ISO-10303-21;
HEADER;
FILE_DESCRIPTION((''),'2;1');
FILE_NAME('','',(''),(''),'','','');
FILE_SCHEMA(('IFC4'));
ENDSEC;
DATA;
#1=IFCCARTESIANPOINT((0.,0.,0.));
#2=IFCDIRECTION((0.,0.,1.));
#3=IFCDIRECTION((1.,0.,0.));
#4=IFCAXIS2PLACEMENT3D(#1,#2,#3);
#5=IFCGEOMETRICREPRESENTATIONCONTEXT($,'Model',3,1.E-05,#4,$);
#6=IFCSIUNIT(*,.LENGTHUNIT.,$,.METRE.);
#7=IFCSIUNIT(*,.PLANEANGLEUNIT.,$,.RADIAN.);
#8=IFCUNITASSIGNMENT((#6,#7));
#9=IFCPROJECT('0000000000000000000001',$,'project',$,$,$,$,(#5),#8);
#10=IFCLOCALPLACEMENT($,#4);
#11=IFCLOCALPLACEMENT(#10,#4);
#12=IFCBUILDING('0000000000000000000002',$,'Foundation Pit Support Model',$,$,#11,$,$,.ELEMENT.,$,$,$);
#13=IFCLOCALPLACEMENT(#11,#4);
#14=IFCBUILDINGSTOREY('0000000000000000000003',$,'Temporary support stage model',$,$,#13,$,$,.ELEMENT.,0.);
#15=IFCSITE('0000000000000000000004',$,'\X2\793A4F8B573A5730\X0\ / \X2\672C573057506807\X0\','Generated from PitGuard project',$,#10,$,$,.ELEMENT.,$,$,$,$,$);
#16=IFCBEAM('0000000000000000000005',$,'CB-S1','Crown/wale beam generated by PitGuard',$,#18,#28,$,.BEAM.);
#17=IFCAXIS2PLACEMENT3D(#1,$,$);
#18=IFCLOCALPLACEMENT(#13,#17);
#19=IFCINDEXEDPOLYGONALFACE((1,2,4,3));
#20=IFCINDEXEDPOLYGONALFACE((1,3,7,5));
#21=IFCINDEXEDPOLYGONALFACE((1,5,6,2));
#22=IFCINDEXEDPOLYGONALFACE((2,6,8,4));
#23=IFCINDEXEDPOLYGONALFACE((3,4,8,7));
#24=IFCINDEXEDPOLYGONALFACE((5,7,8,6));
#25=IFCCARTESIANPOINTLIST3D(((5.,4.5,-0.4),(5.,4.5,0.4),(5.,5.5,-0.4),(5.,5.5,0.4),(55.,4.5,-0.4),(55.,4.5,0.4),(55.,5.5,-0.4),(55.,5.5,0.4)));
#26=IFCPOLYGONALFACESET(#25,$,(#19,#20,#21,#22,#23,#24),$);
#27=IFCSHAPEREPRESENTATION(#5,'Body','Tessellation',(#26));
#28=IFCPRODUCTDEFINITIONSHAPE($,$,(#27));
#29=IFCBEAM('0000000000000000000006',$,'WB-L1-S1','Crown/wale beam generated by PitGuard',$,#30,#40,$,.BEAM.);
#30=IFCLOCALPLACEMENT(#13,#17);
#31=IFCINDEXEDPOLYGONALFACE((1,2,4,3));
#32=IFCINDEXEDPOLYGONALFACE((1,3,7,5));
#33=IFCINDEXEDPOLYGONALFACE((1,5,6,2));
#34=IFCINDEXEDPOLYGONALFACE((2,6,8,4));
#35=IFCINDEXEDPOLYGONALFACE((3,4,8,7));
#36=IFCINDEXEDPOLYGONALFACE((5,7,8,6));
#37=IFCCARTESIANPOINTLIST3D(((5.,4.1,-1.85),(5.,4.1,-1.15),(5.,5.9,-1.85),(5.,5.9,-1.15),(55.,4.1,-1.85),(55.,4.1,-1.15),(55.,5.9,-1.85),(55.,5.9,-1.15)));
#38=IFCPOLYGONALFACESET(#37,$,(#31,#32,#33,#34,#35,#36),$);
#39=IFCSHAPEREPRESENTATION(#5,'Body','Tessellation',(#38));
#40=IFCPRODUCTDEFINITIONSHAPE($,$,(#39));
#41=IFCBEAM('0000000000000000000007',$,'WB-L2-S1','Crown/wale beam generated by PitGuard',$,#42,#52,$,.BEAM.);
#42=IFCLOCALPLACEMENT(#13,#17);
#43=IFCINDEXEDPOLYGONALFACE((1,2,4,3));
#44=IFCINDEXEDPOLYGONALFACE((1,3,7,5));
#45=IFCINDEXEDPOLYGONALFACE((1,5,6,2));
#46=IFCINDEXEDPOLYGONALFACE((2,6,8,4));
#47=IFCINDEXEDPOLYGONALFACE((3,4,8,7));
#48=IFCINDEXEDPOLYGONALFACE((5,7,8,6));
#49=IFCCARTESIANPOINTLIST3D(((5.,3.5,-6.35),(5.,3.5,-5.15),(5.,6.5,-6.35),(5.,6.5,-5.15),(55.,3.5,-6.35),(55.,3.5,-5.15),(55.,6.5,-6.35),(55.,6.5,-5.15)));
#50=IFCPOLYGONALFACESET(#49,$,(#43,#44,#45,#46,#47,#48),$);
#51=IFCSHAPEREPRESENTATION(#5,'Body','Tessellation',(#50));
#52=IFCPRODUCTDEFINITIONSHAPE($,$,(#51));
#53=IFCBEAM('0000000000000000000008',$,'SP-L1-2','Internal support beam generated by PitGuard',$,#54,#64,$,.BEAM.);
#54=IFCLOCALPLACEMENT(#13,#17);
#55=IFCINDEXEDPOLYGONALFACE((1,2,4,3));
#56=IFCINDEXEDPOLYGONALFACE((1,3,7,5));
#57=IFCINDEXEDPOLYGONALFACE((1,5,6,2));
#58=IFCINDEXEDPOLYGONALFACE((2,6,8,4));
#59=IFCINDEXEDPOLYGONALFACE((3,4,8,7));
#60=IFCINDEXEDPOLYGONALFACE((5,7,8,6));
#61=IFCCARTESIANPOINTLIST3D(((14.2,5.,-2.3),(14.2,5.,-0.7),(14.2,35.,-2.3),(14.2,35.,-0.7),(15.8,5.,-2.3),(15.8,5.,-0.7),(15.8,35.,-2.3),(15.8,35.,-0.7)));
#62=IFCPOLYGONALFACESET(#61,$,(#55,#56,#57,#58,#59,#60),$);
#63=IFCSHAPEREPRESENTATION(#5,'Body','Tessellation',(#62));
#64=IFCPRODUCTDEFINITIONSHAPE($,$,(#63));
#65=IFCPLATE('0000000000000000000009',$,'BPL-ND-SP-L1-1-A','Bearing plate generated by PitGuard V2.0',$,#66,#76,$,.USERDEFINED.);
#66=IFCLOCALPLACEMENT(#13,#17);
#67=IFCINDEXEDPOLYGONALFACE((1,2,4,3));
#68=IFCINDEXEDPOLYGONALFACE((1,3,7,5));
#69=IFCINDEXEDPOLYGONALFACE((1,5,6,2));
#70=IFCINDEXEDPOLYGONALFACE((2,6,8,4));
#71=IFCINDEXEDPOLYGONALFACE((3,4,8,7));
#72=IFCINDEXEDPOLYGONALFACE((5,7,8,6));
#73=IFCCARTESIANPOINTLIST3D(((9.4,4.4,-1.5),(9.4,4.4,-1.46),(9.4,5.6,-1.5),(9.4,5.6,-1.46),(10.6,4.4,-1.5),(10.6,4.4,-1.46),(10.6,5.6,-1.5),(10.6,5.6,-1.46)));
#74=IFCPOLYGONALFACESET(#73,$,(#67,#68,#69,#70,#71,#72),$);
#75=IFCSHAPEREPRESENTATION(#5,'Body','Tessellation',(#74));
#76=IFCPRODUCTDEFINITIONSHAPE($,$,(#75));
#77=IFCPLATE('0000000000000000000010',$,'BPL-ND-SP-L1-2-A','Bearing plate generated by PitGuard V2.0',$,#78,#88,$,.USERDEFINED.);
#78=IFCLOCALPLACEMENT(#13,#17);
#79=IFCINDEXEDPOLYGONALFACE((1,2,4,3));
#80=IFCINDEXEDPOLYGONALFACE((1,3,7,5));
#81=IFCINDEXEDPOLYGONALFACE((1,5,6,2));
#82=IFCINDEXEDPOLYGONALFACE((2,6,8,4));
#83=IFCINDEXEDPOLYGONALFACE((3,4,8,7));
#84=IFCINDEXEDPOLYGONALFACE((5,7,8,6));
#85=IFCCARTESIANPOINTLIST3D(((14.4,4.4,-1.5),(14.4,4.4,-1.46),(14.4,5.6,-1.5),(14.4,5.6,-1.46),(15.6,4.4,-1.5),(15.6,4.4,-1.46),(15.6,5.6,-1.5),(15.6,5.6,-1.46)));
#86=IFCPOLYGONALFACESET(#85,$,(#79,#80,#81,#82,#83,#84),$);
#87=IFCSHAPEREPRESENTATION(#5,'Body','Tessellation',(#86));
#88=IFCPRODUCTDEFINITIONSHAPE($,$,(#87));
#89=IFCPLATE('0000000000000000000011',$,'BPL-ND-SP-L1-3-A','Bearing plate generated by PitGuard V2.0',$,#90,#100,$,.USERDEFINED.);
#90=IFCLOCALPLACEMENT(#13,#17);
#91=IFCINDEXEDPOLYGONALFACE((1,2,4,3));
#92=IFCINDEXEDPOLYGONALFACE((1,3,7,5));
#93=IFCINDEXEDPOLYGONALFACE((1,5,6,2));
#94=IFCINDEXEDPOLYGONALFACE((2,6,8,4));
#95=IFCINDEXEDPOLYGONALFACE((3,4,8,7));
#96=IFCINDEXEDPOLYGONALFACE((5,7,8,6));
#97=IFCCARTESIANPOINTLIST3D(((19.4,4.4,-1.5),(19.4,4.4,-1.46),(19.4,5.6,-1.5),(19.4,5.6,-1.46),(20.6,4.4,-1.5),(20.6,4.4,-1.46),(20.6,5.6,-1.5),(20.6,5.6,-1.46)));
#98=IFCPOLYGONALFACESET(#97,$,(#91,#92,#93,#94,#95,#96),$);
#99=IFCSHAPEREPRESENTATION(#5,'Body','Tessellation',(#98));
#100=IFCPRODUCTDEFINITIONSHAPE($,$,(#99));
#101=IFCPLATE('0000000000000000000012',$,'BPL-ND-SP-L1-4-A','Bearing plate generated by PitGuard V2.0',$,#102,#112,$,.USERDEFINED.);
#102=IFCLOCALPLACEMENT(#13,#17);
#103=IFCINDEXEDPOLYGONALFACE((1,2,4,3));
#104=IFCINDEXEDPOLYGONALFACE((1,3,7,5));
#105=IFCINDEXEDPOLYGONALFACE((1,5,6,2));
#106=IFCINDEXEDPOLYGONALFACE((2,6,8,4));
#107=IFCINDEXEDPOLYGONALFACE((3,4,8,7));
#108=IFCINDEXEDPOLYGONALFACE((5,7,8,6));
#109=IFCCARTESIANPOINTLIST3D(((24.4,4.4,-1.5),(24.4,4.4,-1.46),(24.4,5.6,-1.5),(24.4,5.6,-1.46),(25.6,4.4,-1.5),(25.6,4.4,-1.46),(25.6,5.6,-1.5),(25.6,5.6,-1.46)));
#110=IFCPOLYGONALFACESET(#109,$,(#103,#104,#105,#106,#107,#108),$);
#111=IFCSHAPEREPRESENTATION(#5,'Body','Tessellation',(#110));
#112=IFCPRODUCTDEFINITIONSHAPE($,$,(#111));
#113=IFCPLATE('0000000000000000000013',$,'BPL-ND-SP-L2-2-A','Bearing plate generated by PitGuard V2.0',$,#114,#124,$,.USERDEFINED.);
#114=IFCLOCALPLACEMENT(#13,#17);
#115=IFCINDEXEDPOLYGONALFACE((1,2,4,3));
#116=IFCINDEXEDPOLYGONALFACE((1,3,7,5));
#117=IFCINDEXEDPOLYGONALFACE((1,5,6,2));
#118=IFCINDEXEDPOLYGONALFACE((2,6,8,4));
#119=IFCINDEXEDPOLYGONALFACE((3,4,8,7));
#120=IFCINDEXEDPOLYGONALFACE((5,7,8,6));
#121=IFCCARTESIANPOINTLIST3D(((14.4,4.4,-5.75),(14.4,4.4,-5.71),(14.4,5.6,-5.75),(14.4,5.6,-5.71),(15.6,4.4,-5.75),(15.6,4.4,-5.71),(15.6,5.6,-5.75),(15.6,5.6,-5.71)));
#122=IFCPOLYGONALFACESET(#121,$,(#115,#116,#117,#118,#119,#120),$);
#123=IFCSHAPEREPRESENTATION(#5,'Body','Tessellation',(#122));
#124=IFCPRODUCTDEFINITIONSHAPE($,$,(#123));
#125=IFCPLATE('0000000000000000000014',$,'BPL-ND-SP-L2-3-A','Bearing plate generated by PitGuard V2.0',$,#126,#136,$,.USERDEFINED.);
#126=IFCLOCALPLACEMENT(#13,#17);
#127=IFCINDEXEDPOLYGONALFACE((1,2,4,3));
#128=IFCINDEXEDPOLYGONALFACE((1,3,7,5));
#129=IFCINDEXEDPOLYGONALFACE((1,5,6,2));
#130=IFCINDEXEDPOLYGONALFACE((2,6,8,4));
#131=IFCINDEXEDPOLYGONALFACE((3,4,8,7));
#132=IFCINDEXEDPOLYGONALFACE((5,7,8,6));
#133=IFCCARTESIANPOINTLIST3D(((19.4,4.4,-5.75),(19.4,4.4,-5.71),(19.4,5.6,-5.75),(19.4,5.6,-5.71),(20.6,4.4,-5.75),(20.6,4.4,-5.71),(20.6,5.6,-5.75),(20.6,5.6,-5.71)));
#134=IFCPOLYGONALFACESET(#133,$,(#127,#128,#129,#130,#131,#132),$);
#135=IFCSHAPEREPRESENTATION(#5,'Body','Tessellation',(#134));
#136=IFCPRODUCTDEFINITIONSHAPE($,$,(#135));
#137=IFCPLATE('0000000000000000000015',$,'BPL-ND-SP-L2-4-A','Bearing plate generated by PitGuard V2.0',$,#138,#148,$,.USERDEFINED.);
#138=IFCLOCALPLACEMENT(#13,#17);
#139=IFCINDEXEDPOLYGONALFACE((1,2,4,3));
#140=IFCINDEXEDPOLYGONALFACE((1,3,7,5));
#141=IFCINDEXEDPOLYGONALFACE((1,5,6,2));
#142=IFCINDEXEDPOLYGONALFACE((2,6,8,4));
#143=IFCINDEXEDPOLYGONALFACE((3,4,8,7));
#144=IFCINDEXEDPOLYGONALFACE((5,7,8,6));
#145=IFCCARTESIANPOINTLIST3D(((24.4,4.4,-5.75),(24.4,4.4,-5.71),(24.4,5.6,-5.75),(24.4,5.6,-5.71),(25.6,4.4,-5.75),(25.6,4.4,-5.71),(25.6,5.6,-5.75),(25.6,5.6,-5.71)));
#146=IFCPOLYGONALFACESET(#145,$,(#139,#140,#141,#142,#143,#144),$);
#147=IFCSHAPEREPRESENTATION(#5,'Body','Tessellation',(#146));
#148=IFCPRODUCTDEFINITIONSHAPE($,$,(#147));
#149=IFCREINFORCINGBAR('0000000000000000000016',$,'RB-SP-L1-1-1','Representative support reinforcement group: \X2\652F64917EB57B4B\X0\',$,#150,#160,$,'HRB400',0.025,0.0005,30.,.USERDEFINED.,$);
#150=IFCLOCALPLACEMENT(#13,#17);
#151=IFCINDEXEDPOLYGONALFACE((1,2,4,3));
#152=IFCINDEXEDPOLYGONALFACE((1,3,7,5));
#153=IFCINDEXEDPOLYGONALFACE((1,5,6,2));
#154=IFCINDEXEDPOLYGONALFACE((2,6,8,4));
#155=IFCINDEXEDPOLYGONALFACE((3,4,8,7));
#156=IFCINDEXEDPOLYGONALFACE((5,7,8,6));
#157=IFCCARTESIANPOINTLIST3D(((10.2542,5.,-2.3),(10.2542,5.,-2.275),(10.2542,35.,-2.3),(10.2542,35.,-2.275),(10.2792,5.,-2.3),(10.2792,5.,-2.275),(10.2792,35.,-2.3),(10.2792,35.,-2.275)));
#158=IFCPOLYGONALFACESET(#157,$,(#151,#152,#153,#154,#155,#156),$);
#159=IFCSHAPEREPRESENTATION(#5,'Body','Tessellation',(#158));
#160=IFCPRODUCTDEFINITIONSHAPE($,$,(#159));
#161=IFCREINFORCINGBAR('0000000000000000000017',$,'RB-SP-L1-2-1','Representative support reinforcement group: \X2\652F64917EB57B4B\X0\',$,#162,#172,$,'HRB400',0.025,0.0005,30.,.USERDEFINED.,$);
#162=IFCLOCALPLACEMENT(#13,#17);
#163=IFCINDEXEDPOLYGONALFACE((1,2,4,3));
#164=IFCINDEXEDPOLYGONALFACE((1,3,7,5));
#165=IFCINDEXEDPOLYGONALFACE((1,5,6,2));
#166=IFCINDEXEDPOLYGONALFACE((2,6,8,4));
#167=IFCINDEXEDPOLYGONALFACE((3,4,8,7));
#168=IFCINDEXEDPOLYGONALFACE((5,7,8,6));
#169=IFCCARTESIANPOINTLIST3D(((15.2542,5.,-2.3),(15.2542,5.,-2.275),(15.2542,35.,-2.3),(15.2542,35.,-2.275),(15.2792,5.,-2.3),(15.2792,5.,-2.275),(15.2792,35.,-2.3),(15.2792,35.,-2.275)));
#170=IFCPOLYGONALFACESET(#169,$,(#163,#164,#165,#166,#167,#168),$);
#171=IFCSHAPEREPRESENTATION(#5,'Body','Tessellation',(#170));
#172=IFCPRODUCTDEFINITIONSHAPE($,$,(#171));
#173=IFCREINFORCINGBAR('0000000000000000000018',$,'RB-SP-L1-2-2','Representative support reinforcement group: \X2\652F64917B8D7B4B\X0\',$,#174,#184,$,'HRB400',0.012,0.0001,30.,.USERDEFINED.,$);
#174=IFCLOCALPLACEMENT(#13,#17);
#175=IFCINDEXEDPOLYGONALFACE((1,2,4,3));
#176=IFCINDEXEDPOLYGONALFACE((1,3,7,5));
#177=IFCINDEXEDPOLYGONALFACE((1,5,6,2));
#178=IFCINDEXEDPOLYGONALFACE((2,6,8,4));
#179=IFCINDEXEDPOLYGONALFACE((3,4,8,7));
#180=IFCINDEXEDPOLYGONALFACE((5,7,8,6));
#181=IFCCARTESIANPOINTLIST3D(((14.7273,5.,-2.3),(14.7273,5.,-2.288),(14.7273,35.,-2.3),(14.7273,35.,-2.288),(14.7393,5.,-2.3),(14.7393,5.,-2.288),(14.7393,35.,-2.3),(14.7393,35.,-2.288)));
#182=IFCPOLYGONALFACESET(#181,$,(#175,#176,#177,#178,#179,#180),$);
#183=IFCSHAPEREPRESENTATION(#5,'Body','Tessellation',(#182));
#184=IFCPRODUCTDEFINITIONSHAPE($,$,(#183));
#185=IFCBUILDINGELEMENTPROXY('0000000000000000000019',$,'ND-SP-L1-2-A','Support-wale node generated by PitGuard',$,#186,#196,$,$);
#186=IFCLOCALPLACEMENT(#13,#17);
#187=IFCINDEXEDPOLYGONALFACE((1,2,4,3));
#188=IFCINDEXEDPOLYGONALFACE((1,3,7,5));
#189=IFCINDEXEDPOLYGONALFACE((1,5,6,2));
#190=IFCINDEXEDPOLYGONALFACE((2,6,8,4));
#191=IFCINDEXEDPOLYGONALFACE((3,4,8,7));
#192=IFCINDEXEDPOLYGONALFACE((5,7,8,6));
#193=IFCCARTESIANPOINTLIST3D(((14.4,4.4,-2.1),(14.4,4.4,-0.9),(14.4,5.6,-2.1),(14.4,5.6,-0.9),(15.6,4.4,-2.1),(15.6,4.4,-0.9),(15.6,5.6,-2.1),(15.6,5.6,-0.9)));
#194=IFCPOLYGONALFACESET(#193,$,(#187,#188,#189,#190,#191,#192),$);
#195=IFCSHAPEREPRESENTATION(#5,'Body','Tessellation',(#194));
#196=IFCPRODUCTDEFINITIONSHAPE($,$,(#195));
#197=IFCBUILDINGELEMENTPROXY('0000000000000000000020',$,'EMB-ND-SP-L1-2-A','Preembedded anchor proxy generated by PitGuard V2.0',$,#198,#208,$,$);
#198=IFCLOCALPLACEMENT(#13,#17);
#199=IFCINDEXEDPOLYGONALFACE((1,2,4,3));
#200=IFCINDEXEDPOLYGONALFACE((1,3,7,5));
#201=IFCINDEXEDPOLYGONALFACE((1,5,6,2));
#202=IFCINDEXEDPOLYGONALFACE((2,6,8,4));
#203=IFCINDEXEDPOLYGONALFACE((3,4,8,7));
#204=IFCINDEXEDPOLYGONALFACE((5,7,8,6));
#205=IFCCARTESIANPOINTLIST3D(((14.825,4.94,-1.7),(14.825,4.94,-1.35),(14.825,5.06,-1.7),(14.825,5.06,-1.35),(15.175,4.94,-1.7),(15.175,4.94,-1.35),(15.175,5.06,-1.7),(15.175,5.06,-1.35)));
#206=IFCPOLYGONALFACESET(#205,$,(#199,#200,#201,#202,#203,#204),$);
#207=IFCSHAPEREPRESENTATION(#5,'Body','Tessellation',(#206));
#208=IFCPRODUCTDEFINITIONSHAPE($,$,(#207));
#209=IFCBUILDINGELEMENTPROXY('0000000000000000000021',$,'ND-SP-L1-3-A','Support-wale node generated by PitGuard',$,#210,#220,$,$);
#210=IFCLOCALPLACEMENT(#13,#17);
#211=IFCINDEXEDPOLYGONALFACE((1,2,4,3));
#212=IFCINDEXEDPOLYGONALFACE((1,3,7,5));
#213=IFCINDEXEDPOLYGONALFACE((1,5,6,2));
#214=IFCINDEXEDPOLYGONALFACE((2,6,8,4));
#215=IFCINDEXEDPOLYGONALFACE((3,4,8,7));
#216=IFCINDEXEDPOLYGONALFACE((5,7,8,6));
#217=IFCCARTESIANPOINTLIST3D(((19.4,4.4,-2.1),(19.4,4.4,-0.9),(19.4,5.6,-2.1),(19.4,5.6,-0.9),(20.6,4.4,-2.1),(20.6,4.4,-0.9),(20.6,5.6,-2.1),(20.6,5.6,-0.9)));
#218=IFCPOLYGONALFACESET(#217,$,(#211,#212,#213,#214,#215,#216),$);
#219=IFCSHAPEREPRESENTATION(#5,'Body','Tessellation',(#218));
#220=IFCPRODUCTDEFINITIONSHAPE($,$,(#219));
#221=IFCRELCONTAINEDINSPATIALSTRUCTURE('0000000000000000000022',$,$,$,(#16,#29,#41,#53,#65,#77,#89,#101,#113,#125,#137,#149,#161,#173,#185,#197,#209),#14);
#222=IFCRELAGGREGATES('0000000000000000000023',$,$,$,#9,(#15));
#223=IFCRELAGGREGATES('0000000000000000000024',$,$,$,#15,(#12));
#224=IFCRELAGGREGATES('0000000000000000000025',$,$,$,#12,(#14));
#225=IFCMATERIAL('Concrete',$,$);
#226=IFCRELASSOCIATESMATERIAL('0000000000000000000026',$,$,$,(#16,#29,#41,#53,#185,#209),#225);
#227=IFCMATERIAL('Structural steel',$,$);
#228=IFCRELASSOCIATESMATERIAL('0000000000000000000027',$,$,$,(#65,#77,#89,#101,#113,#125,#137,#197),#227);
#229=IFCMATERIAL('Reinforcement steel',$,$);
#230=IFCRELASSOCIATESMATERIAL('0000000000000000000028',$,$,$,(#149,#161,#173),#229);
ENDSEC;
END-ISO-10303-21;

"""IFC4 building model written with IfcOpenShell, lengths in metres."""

from ifc_helpers import new_model, si_unit, frame, origin_with_axes, origin_2d, place, context, project, spatial, rectangle, extrude, material, element, save


model = new_model("IFC4")

# Units and contexts
model_context = context("Model", 3, precision=1e-05, world=origin_with_axes())
ifc_project = project(units=[si_unit("LENGTHUNIT", "METRE"), si_unit("PLANEANGLEUNIT", "RADIAN")], contexts=[model_context])

# Site, building, storey
site_placement = place(None, origin_with_axes())
site = spatial("IfcSite", under=ifc_project, at=site_placement, Name="示例场地 / 本地坐标", Description="Generated from PitGuard project", CompositionType="ELEMENT")
building_placement = place(site_placement, origin_with_axes())
building = spatial("IfcBuilding", under=site, at=building_placement, Name="Foundation Pit Support Model", CompositionType="ELEMENT")
storey_placement = place(building_placement, origin_with_axes())
storey = spatial("IfcBuildingStorey", under=building, at=storey_placement, Name="Temporary support stage model", CompositionType="ELEMENT", Elevation=0.0)

# Beams
ifc_material_1 = material(Name="Concrete")
beam_1_placement = place(storey_placement, frame((30.0, 5.0, -0.4), z_axis=(0.0, 0.0, 1.0), x_axis=(1.0, 0.0, 0.0)))
element("IfcBeam", 1, at=beam_1_placement, inside=storey, material=ifc_material_1, Name="CB-S1", Description="Crown/wale beam generated by PitGuard", PredefinedType="BEAM", context=model_context, shape_type="SweptSolid", body=[
    extrude(rectangle(XDim=50.0, YDim=1.0, at=origin_2d()), origin_with_axes(), (0.0, 0.0, 1.0), 0.8),
])
beam_2_placement = place(storey_placement, frame((30.0, 5.0, -1.85), z_axis=(0.0, 0.0, 1.0), x_axis=(1.0, 0.0, 0.0)))
element("IfcBeam", 2, at=beam_2_placement, inside=storey, material=ifc_material_1, Name="WB-L1-S1", Description="Crown/wale beam generated by PitGuard", PredefinedType="BEAM", context=model_context, shape_type="SweptSolid", body=[
    extrude(rectangle(XDim=50.0, YDim=1.8, at=origin_2d()), origin_with_axes(), (0.0, 0.0, 1.0), 0.7),
])
beam_3_placement = place(storey_placement, frame((30.0, 5.0, -6.35), z_axis=(0.0, 0.0, 1.0), x_axis=(1.0, 0.0, 0.0)))
element("IfcBeam", 3, at=beam_3_placement, inside=storey, material=ifc_material_1, Name="WB-L2-S1", Description="Crown/wale beam generated by PitGuard", PredefinedType="BEAM", context=model_context, shape_type="SweptSolid", body=[
    extrude(rectangle(XDim=50.0, YDim=3.0, at=origin_2d()), origin_with_axes(), (0.0, 0.0, 1.0), 1.2),
])
beam_4_placement = place(storey_placement, frame((15.0, 20.0, -2.3), z_axis=(0.0, 0.0, 1.0), x_axis=(0.0, 1.0, 0.0)))
element("IfcBeam", 4, at=beam_4_placement, inside=storey, material=ifc_material_1, Name="SP-L1-2", Description="Internal support beam generated by PitGuard", PredefinedType="BEAM", context=model_context, shape_type="SweptSolid", body=[
    extrude(rectangle(XDim=30.0, YDim=1.6, at=origin_2d()), origin_with_axes(), (0.0, 0.0, 1.0), 1.6),
])

# Plates
ifc_material_2 = material(Name="Structural steel")
for number, where, z_axis, x_axis, name in (
    (5, (10.0, 5.0, -1.5), (0.0, 0.0, 1.0), (1.0, 0.0, 0.0), "BPL-ND-SP-L1-1-A"),
    (6, (15.0, 5.0, -1.5), (0.0, 0.0, 1.0), (1.0, 0.0, 0.0), "BPL-ND-SP-L1-2-A"),
    (7, (20.0, 5.0, -1.5), (0.0, 0.0, 1.0), (1.0, 0.0, 0.0), "BPL-ND-SP-L1-3-A"),
    (8, (25.0, 5.0, -1.5), (0.0, 0.0, 1.0), (1.0, 0.0, 0.0), "BPL-ND-SP-L1-4-A"),
    (9, (15.0, 5.0, -5.75), (0.0, 0.0, 1.0), (1.0, 0.0, 0.0), "BPL-ND-SP-L2-2-A"),
    (10, (20.0, 5.0, -5.75), (0.0, 0.0, 1.0), (1.0, 0.0, 0.0), "BPL-ND-SP-L2-3-A"),
    (11, (25.0, 5.0, -5.75), (0.0, 0.0, 1.0), (1.0, 0.0, 0.0), "BPL-ND-SP-L2-4-A"),
):
    element("IfcPlate", number, at=place(storey_placement, frame(where, z_axis=z_axis, x_axis=x_axis)), inside=storey, material=ifc_material_2, Name=name, Description="Bearing plate generated by PitGuard V2.0", PredefinedType="USERDEFINED", context=model_context, shape_type="SweptSolid", body=[
        extrude(rectangle(XDim=1.2, YDim=1.2, at=origin_2d()), origin_with_axes(), (0.0, 0.0, 1.0), 0.04),
    ])

# Reinforcing bars
ifc_material_3 = material(Name="Reinforcement steel")
for number, where, z_axis, x_axis, name in (
    (12, (10.2667, 20.0, -2.3), (0.0, 0.0, 1.0), (0.0, 1.0, 0.0), "RB-SP-L1-1-1"),
    (13, (15.2667, 20.0, -2.3), (0.0, 0.0, 1.0), (0.0, 1.0, 0.0), "RB-SP-L1-2-1"),
):
    element("IfcReinforcingBar", number, at=place(storey_placement, frame(where, z_axis=z_axis, x_axis=x_axis)), inside=storey, material=ifc_material_3, Name=name, Description="Representative support reinforcement group: 支撑纵筋", SteelGrade="HRB400", BarLength=30.0, CrossSectionArea=0.0005, NominalDiameter=0.025, PredefinedType="USERDEFINED", context=model_context, shape_type="SweptSolid", body=[
        extrude(rectangle(XDim=30.0, YDim=0.025, at=origin_2d()), origin_with_axes(), (0.0, 0.0, 1.0), 0.025),
    ])
reinforcing_bar_placement = place(storey_placement, frame((14.7333, 20.0, -2.3), z_axis=(0.0, 0.0, 1.0), x_axis=(0.0, 1.0, 0.0)))
element("IfcReinforcingBar", 14, at=reinforcing_bar_placement, inside=storey, material=ifc_material_3, Name="RB-SP-L1-2-2", Description="Representative support reinforcement group: 支撑箍筋", SteelGrade="HRB400", BarLength=30.0, CrossSectionArea=0.0001, NominalDiameter=0.012, PredefinedType="USERDEFINED", context=model_context, shape_type="SweptSolid", body=[
    extrude(rectangle(XDim=30.0, YDim=0.012, at=origin_2d()), origin_with_axes(), (0.0, 0.0, 1.0), 0.012),
])

# Building element proxies
proxy_1_placement = place(storey_placement, frame((15.0, 5.0, -2.1), z_axis=(0.0, 0.0, 1.0), x_axis=(1.0, 0.0, 0.0)))
element("IfcBuildingElementProxy", 15, at=proxy_1_placement, inside=storey, material=ifc_material_1, Name="ND-SP-L1-2-A", Description="Support-wale node generated by PitGuard", context=model_context, shape_type="SweptSolid", body=[
    extrude(rectangle(XDim=1.2, YDim=1.2, at=origin_2d()), origin_with_axes(), (0.0, 0.0, 1.0), 1.2),
])
proxy_2_placement = place(storey_placement, frame((15.0, 5.0, -1.7), z_axis=(0.0, 0.0, 1.0), x_axis=(1.0, 0.0, 0.0)))
element("IfcBuildingElementProxy", 16, at=proxy_2_placement, inside=storey, material=ifc_material_2, Name="EMB-ND-SP-L1-2-A", Description="Preembedded anchor proxy generated by PitGuard V2.0", context=model_context, shape_type="SweptSolid", body=[
    extrude(rectangle(XDim=0.35, YDim=0.12, at=origin_2d()), origin_with_axes(), (0.0, 0.0, 1.0), 0.35),
])
proxy_3_placement = place(storey_placement, frame((20.0, 5.0, -2.1), z_axis=(0.0, 0.0, 1.0), x_axis=(1.0, 0.0, 0.0)))
element("IfcBuildingElementProxy", 17, at=proxy_3_placement, inside=storey, material=ifc_material_1, Name="ND-SP-L1-3-A", Description="Support-wale node generated by PitGuard", context=model_context, shape_type="SweptSolid", body=[
    extrude(rectangle(XDim=1.2, YDim=1.2, at=origin_2d()), origin_with_axes(), (0.0, 0.0, 1.0), 1.2),
])

save(model, "model.ifc")
